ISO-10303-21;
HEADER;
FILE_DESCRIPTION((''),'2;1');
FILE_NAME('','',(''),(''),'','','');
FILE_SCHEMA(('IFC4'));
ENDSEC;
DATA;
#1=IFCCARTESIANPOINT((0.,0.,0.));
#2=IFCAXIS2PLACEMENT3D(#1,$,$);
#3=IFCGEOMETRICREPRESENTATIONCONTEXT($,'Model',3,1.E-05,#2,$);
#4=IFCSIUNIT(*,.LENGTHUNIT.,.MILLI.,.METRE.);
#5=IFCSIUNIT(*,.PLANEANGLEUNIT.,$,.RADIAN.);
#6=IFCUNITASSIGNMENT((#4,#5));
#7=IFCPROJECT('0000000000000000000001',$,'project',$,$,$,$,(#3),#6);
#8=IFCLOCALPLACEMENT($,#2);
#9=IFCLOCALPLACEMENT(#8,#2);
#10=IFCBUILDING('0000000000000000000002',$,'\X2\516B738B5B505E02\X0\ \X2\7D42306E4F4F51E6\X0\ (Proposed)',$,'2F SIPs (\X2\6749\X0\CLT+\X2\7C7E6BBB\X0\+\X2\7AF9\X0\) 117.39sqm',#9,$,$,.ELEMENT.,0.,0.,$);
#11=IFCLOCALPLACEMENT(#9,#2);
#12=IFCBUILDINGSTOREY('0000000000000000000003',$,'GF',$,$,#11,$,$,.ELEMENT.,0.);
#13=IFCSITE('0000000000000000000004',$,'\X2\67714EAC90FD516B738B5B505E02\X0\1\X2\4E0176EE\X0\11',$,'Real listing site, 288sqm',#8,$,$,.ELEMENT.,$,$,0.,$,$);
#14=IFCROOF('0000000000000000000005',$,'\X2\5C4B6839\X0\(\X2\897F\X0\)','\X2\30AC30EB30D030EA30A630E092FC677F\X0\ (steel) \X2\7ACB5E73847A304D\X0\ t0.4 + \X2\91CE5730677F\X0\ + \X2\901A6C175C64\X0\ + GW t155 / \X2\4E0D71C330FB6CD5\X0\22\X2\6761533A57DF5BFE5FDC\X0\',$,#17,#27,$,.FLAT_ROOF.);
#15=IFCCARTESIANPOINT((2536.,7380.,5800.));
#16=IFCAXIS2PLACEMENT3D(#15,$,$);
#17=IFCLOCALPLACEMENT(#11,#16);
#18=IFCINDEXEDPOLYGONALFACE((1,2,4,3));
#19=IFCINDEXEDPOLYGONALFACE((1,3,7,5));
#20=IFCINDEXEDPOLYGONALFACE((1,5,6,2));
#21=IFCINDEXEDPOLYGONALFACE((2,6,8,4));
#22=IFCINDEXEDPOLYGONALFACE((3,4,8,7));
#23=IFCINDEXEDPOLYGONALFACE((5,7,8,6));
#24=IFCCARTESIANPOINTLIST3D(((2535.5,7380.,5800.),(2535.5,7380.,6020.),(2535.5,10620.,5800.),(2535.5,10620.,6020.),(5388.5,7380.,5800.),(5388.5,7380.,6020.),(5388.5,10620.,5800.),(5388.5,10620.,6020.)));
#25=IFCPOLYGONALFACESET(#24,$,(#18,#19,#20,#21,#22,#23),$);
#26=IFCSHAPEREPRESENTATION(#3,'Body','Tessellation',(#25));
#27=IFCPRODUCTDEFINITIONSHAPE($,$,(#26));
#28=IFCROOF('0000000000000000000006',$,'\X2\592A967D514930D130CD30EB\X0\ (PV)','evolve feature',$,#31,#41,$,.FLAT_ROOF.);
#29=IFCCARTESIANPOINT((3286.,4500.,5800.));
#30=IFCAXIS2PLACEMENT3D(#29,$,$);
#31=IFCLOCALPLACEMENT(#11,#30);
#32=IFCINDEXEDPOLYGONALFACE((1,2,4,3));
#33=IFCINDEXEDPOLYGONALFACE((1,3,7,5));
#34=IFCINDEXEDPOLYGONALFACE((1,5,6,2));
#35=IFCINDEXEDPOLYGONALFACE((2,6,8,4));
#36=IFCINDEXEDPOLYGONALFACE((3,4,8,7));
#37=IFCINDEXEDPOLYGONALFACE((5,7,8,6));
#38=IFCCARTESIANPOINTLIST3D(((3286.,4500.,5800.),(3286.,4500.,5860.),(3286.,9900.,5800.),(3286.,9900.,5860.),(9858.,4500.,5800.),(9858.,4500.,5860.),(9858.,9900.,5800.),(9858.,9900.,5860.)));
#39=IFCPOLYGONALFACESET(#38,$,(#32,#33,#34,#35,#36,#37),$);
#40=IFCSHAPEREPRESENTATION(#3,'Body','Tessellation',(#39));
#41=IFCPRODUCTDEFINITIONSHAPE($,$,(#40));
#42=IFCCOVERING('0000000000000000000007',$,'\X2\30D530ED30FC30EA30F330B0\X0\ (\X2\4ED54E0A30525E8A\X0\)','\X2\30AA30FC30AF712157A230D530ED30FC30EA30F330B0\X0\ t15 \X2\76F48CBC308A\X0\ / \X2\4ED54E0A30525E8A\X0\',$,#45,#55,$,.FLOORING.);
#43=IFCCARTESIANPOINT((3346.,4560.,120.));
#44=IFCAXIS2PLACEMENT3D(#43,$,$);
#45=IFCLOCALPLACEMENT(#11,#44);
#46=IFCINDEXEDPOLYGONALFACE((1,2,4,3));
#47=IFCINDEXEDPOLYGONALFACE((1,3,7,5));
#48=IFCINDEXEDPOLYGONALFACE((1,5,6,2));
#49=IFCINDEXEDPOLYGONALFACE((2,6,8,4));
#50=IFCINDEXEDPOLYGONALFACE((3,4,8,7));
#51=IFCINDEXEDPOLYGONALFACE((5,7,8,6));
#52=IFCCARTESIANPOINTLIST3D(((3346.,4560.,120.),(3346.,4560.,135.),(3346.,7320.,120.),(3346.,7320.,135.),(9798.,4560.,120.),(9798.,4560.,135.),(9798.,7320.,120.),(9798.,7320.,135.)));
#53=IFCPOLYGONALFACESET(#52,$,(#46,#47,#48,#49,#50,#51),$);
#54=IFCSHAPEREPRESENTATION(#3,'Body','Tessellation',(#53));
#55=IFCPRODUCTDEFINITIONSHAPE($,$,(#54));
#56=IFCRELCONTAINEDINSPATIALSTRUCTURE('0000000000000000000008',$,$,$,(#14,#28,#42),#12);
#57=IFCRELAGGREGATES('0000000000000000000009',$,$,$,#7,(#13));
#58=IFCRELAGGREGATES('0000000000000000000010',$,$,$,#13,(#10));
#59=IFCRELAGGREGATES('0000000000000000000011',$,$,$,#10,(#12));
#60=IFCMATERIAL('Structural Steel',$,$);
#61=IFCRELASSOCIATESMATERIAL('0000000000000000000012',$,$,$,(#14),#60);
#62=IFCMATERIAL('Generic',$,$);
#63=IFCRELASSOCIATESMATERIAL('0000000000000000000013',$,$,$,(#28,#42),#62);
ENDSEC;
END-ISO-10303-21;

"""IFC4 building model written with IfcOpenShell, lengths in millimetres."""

from ifc_helpers import new_model, si_unit, frame, frame_2d, origin, place, context, project, spatial, rectangle, extrude, material, element, save


model = new_model("IFC4")

# Units and contexts
model_context = context("Model", 3, precision=1e-05, world=origin())
ifc_project = project(units=[si_unit("LENGTHUNIT", "METRE", prefix="MILLI"), si_unit("PLANEANGLEUNIT", "RADIAN")], contexts=[model_context])

# Site, building, storey
site_placement = place(None, origin())
site = spatial("IfcSite", under=ifc_project, at=site_placement, Name="東京都八王子市1丁目11", ObjectType="Real listing site, 288sqm", CompositionType="ELEMENT", RefElevation=0.0)
building_placement = place(site_placement, origin())
building = spatial("IfcBuilding", under=site, at=building_placement, Name="八王子市 終の住処 (Proposed)", ObjectType="2F SIPs (杉CLT+籾殻+竹) 117.39sqm", CompositionType="ELEMENT", ElevationOfRefHeight=0.0, ElevationOfTerrain=0.0)
storey_placement = place(building_placement, origin())
storey = spatial("IfcBuildingStorey", under=building, at=storey_placement, Name="GF", CompositionType="ELEMENT", Elevation=0.0)

# Shared definitions
ifc_material_1 = material(Name="Generic")

# Roofs
ifc_material_2 = material(Name="Structural Steel")
roof_1_placement = place(storey_placement, frame((2536.0, 7380.0, 5800.0)))
element("IfcRoof", 1, at=roof_1_placement, inside=storey, material=ifc_material_2, Name="屋根(西)", Description="ガルバリウム鋼板 (steel) 立平葺き t0.4 + 野地板 + 通気層 + GW t155 / 不燃・法22条区域対応", PredefinedType="FLAT_ROOF", context=model_context, shape_type="SweptSolid", body=[
    extrude(rectangle(XDim=2853.0, YDim=3240.0, at=frame_2d((1426.0, 1620.0))), frame((2536.0, 7380.0, 5800.0)), (0.0, 0.0, 1.0), 220.0),
])
roof_2_placement = place(storey_placement, frame((3286.0, 4500.0, 5800.0)))
element("IfcRoof", 2, at=roof_2_placement, inside=storey, material=ifc_material_1, Name="太陽光パネル (PV)", Description="evolve feature", PredefinedType="FLAT_ROOF", context=model_context, shape_type="SweptSolid", body=[
    extrude(rectangle(XDim=6572.0, YDim=5400.0, at=frame_2d((3286.0, 2700.0))), frame((3286.0, 4500.0, 5800.0)), (0.0, 0.0, 1.0), 60.0),
])

# Covering
covering_placement = place(storey_placement, frame((3346.0, 4560.0, 120.0)))
element("IfcCovering", 3, at=covering_placement, inside=storey, material=ifc_material_1, Name="フローリング (仕上げ床)", Description="オーク無垢フローリング t15 直貼り / 仕上げ床", PredefinedType="FLOORING", context=model_context, shape_type="SweptSolid", body=[
    extrude(rectangle(XDim=6452.0, YDim=2760.0, at=frame_2d((3226.0, 1380.0))), frame((3346.0, 4560.0, 120.0)), (0.0, 0.0, 1.0), 15.0),
])

save(model, "model.ifc")
